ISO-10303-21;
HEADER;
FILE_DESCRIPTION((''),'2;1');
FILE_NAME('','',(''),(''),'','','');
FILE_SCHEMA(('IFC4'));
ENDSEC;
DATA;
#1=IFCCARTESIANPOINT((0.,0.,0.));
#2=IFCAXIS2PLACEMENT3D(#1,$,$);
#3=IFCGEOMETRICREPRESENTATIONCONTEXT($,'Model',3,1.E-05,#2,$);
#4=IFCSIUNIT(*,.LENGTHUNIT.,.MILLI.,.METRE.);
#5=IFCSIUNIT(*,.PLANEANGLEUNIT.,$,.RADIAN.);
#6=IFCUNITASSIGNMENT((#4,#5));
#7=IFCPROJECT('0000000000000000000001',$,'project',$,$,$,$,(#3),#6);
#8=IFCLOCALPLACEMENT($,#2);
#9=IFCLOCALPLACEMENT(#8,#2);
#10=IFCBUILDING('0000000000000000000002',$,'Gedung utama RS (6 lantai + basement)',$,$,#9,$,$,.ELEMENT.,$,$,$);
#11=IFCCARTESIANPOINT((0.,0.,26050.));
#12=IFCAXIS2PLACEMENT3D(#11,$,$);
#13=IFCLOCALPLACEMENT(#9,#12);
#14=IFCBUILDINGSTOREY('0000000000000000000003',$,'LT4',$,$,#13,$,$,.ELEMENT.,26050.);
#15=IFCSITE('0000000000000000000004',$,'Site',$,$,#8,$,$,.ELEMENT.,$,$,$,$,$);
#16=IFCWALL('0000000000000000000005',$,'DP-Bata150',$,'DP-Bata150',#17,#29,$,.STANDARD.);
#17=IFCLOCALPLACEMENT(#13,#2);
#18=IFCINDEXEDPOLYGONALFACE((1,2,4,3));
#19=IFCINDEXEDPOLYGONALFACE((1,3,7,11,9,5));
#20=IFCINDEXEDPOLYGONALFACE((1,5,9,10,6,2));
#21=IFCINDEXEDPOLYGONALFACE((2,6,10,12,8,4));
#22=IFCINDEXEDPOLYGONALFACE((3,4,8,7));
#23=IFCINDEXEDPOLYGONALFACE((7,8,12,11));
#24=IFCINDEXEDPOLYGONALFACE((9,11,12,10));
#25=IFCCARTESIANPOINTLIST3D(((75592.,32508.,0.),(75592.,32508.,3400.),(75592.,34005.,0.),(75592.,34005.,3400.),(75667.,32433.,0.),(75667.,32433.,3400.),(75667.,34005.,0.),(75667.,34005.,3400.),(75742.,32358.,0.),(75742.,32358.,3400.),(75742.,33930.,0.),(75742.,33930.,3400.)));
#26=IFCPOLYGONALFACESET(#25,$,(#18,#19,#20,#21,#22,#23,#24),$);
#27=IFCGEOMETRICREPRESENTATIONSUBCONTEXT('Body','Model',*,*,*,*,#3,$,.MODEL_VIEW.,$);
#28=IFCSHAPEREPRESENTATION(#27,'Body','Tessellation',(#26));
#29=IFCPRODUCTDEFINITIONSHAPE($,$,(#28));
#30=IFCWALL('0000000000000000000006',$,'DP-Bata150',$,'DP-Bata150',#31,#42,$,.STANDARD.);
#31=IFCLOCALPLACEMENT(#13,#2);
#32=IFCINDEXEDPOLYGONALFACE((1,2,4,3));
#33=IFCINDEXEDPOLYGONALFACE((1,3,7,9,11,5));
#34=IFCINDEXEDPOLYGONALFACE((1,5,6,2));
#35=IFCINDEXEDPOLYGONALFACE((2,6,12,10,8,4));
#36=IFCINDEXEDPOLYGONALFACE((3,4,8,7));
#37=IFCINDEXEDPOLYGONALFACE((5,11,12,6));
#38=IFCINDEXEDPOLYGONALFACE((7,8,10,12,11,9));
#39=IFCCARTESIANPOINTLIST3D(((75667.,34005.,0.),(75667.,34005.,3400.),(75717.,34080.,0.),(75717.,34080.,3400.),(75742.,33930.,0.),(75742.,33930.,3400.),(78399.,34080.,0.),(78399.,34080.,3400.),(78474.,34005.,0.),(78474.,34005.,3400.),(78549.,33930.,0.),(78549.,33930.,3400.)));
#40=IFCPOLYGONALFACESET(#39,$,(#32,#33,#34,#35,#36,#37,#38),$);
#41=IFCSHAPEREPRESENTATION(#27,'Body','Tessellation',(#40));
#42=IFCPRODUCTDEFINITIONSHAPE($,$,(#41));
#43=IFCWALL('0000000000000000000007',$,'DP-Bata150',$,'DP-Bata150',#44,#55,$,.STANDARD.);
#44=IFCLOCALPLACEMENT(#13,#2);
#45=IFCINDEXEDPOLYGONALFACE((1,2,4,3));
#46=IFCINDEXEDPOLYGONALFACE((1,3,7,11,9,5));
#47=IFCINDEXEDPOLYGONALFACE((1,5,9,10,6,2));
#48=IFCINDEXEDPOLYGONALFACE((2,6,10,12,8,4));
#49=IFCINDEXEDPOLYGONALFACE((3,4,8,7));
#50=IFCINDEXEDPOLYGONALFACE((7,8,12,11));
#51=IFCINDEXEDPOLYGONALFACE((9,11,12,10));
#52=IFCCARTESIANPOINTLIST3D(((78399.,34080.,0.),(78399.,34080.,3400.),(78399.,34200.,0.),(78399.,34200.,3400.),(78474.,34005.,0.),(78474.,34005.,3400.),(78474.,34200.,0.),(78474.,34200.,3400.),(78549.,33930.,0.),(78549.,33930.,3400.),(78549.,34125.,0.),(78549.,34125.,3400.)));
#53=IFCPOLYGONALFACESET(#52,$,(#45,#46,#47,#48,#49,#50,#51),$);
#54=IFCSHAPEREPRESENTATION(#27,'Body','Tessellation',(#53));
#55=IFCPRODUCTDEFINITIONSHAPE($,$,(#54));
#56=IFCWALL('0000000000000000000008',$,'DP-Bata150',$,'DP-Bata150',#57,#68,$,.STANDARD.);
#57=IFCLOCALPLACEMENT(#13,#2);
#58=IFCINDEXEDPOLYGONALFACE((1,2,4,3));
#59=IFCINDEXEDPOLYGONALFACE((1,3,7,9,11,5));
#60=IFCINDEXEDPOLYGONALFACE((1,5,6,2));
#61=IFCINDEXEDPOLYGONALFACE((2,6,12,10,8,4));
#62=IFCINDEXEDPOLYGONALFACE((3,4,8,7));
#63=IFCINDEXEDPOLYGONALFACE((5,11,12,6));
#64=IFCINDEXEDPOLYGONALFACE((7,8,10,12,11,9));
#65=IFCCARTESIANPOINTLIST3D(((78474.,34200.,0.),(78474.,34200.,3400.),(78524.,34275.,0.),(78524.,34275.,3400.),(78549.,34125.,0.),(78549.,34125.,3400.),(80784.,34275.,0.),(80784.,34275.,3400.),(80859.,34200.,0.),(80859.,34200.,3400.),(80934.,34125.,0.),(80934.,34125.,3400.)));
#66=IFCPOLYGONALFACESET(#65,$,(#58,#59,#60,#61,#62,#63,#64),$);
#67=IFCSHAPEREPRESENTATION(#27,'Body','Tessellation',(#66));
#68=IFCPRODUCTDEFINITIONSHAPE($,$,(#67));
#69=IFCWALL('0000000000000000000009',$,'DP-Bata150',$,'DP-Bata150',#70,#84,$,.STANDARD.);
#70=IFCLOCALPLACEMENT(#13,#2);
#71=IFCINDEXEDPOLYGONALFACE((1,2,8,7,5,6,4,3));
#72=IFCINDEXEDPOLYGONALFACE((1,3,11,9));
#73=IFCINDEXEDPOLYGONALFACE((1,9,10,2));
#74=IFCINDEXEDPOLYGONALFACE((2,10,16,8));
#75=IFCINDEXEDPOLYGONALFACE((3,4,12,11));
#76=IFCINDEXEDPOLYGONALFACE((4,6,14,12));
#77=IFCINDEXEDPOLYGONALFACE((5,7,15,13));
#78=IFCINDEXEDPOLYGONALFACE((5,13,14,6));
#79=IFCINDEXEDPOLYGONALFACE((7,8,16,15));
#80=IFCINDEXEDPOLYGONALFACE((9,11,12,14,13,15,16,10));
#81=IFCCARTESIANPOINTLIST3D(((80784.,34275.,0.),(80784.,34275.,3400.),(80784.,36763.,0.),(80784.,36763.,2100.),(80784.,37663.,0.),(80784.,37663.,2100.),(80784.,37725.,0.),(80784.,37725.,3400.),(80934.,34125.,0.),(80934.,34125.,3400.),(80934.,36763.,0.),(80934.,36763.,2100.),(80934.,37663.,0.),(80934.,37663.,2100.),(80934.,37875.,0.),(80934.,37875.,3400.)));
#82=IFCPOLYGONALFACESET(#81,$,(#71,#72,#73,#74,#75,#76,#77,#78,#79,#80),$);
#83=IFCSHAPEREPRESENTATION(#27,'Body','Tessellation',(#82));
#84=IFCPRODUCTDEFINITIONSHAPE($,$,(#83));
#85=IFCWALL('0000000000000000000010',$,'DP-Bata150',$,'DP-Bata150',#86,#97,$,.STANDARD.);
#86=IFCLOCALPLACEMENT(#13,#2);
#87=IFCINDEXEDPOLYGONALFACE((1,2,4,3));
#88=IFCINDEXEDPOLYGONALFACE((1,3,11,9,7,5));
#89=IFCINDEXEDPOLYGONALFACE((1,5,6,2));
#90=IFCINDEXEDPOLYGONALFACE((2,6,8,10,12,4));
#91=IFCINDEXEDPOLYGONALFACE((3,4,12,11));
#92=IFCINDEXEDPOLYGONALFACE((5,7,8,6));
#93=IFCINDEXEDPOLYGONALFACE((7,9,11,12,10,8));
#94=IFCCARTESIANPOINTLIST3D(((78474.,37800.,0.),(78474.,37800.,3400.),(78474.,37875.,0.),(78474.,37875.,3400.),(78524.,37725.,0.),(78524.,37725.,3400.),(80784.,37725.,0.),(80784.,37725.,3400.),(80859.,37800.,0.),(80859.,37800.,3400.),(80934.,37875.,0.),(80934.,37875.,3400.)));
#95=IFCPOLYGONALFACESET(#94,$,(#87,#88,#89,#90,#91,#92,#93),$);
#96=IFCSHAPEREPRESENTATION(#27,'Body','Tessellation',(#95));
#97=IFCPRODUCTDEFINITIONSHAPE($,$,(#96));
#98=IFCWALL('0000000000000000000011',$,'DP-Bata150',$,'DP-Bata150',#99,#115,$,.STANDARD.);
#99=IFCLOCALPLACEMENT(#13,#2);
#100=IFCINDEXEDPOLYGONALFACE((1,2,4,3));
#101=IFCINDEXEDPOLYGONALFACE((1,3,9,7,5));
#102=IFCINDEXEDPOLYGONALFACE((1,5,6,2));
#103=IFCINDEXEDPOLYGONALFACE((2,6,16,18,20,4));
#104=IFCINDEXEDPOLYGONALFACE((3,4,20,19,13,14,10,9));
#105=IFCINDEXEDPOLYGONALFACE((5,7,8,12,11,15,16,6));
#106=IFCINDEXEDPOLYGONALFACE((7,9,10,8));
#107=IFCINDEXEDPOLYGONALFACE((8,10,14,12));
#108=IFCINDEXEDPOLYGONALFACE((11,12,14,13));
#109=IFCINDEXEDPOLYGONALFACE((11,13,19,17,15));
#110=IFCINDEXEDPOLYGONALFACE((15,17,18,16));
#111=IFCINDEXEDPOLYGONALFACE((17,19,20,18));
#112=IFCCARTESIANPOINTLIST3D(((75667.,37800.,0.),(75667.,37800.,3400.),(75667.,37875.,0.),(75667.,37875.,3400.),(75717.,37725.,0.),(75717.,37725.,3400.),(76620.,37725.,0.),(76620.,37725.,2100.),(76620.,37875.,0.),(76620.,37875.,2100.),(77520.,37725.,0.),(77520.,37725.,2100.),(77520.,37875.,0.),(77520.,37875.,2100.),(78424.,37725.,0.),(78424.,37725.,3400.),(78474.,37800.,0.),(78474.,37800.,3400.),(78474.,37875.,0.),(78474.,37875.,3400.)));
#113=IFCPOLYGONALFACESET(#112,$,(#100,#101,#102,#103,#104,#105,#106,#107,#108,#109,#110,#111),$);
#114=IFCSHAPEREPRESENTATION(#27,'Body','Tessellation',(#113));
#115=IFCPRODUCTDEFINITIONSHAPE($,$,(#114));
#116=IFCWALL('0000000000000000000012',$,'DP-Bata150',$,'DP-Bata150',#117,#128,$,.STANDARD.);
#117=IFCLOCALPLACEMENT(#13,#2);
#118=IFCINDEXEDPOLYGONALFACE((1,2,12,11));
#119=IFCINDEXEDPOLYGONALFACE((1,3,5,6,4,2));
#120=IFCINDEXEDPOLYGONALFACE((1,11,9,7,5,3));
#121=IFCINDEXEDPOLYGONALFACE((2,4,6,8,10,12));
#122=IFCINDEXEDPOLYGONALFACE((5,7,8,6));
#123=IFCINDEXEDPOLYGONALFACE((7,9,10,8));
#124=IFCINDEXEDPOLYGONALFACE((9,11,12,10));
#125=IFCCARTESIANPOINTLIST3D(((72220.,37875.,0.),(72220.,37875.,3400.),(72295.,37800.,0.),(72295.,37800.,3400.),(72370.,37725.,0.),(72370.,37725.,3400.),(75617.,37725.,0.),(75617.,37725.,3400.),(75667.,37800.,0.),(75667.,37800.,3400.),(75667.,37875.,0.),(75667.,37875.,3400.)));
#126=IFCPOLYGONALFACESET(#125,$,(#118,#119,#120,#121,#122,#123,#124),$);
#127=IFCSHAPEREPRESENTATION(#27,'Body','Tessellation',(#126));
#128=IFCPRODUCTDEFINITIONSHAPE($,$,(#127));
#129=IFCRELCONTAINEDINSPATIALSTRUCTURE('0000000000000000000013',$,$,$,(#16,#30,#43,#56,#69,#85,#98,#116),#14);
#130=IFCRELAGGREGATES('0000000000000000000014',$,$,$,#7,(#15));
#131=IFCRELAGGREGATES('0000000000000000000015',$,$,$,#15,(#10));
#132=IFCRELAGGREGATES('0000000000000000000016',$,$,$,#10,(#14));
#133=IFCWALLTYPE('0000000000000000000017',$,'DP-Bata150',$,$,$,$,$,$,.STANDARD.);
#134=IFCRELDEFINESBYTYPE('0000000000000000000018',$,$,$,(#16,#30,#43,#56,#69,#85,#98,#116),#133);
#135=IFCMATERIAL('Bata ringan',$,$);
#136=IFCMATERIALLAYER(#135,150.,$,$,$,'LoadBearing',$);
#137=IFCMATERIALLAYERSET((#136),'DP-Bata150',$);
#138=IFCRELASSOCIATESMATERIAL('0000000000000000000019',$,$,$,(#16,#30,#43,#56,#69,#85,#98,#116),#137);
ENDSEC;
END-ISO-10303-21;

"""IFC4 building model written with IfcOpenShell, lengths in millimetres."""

from ifc_helpers import new_model, si_unit, frame, frame_2d, origin, place, context, subcontext, project, spatial, polyline, rectangle, outline, extrude, material, layer, layer_set, layer_usage, type_object, element, save


model = new_model("IFC4")

# Units and contexts
model_context = context("Model", 3, precision=1e-05, world=origin())
body_context = subcontext(model_context, "Body", "Model", "MODEL_VIEW")
ifc_project = project(units=[si_unit("LENGTHUNIT", "METRE", prefix="MILLI"), si_unit("PLANEANGLEUNIT", "RADIAN")], contexts=[model_context])

# Site, building, storey
site_placement = place(None, origin())
site = spatial("IfcSite", under=ifc_project, at=site_placement, Name="Site", CompositionType="ELEMENT")
building_placement = place(site_placement, origin())
building = spatial("IfcBuilding", under=site, at=building_placement, Name="Gedung utama RS (6 lantai + basement)", CompositionType="ELEMENT")
storey_placement = place(building_placement, frame((0.0, 0.0, 26050.0)))
storey = spatial("IfcBuildingStorey", under=building, at=storey_placement, Name="LT4", CompositionType="ELEMENT", Elevation=26050.0)

# Shared definitions
ifc_material = material(Name="Bata ringan")
ifc_layer_1 = layer(ifc_material, 150.0, Category="LoadBearing")
ifc_layer_set_1 = layer_set([ifc_layer_1], Name="DP-Bata150")
ifc_layer_usage_1 = layer_usage(ifc_layer_set_1, "AXIS2", "NEGATIVE", 75.0)
wall_type_1 = type_object("IfcWallType", Name="DP-Bata150", PredefinedType="STANDARD")

# Walls
wall_1_placement = place(storey_placement, frame((75667.0, 32433.0, 0.0), z_axis=(0.0, 0.0, 1.0), x_axis=(0.0, 1.0, 0.0)))
element("IfcWall", 1, at=wall_1_placement, inside=storey, type_object=wall_type_1, material=ifc_layer_usage_1, Name="DP-Bata150", ObjectType="DP-Bata150", PredefinedType="STANDARD", context=body_context, shape_type="SweptSolid", body=[
    extrude(outline(polyline([(-75.0, -75.0), (0.0, 0.0), (75.0, 75.0), (1572.0, 75.0), (1572.0, 0.0), (1497.0, -75.0), (-75.0, -75.0)])), origin(), (0.0, 0.0, 1.0), 3400.0),
])
wall_2_placement = place(storey_placement, frame((75667.0, 34005.0, 0.0), z_axis=(0.0, 0.0, 1.0), x_axis=(1.0, 0.0, 0.0)))
element("IfcWall", 2, at=wall_2_placement, inside=storey, type_object=wall_type_1, material=ifc_layer_usage_1, Name="DP-Bata150", ObjectType="DP-Bata150", PredefinedType="STANDARD", context=body_context, shape_type="SweptSolid", body=[
    extrude(outline(polyline([(75.0, -75.0), (0.0, 0.0), (50.0, 75.0), (2732.0, 75.0), (2807.0, 0.0), (2882.0, -75.0), (75.0, -75.0)])), origin(), (0.0, 0.0, 1.0), 3400.0),
])
wall_3_placement = place(storey_placement, frame((78474.0, 34005.0, 0.0), z_axis=(0.0, 0.0, 1.0), x_axis=(0.0, 1.0, 0.0)))
element("IfcWall", 3, at=wall_3_placement, inside=storey, type_object=wall_type_1, material=ifc_layer_usage_1, Name="DP-Bata150", ObjectType="DP-Bata150", PredefinedType="STANDARD", context=body_context, shape_type="SweptSolid", body=[
    extrude(outline(polyline([(-75.0, -75.0), (0.0, 0.0), (75.0, 75.0), (195.0, 75.0), (195.0, 0.0), (120.0, -75.0), (-75.0, -75.0)])), origin(), (0.0, 0.0, 1.0), 3400.0),
])
wall_4_placement = place(storey_placement, frame((78474.0, 34200.0, 0.0), z_axis=(0.0, 0.0, 1.0), x_axis=(1.0, 0.0, 0.0)))
element("IfcWall", 4, at=wall_4_placement, inside=storey, type_object=wall_type_1, material=ifc_layer_usage_1, Name="DP-Bata150", ObjectType="DP-Bata150", PredefinedType="STANDARD", context=body_context, shape_type="SweptSolid", body=[
    extrude(outline(polyline([(75.0, -75.0), (0.0, 0.0), (50.0, 75.0), (2310.0, 75.0), (2385.0, 0.0), (2460.0, -75.0), (75.0, -75.0)])), origin(), (0.0, 0.0, 1.0), 3400.0),
])

# Wall, opening
wall_5_placement = place(storey_placement, frame((80859.0, 34200.0, 0.0), z_axis=(0.0, 0.0, 1.0), x_axis=(0.0, 1.0, 0.0)))
wall_5 = element("IfcWall", 5, at=wall_5_placement, inside=storey, type_object=wall_type_1, material=ifc_layer_usage_1, Name="DP-Bata150", ObjectType="DP-Bata150", PredefinedType="STANDARD", context=body_context, shape_type="SweptSolid", body=[
    extrude(outline(polyline([(-75.0, -75.0), (0.0, 0.0), (75.0, 75.0), (3525.0, 75.0), (3600.0, 0.0), (3675.0, -75.0), (-75.0, -75.0)])), origin(), (0.0, 0.0, 1.0), 3400.0),
])
opening_1_placement = place(wall_5_placement, frame((2563.0, 0.0, 0.0), z_axis=(0.0, 0.0, 1.0), x_axis=(1.0, 0.0, 0.0)))
element("IfcOpeningElement", 6, at=opening_1_placement, cuts=wall_5, PredefinedType="OPENING", context=body_context, shape_type="SweptSolid", body=[
    extrude(rectangle(XDim=900.0, YDim=170.0, at=frame_2d((450.0, 0.0))), origin(), (0.0, 0.0, 1.0), 2100.0),
])

# Wall
wall_6_placement = place(storey_placement, frame((80859.0, 37800.0, 0.0), z_axis=(0.0, 0.0, 1.0), x_axis=(-1.0, 0.0, 0.0)))
element("IfcWall", 7, at=wall_6_placement, inside=storey, type_object=wall_type_1, material=ifc_layer_usage_1, Name="DP-Bata150", ObjectType="DP-Bata150", PredefinedType="STANDARD", context=body_context, shape_type="SweptSolid", body=[
    extrude(outline(polyline([(-75.0, -75.0), (0.0, 0.0), (75.0, 75.0), (2335.0, 75.0), (2385.0, 0.0), (2385.0, -75.0), (-75.0, -75.0)])), origin(), (0.0, 0.0, 1.0), 3400.0),
])

# Wall, opening
wall_7_placement = place(storey_placement, frame((78474.0, 37800.0, 0.0), z_axis=(0.0, 0.0, 1.0), x_axis=(-1.0, 0.0, 0.0)))
wall_7 = element("IfcWall", 8, at=wall_7_placement, inside=storey, type_object=wall_type_1, material=ifc_layer_usage_1, Name="DP-Bata150", ObjectType="DP-Bata150", PredefinedType="STANDARD", context=body_context, shape_type="SweptSolid", body=[
    extrude(outline(polyline([(0.0, -75.0), (0.0, 0.0), (50.0, 75.0), (2757.0, 75.0), (2807.0, 0.0), (2807.0, -75.0), (0.0, -75.0)])), origin(), (0.0, 0.0, 1.0), 3400.0),
])
opening_2_placement = place(wall_7_placement, frame((954.0, 0.0, 0.0), z_axis=(0.0, 0.0, 1.0), x_axis=(1.0, 0.0, 0.0)))
element("IfcOpeningElement", 9, at=opening_2_placement, cuts=wall_7, PredefinedType="OPENING", context=body_context, shape_type="SweptSolid", body=[
    extrude(rectangle(XDim=900.0, YDim=170.0, at=frame_2d((450.0, 0.0))), origin(), (0.0, 0.0, 1.0), 2100.0),
])

# Wall
wall_8_placement = place(storey_placement, frame((75667.0, 37800.0, 0.0), z_axis=(0.0, 0.0, 1.0), x_axis=(-1.0, 0.0, 0.0)))
element("IfcWall", 10, at=wall_8_placement, inside=storey, type_object=wall_type_1, material=ifc_layer_usage_1, Name="DP-Bata150", ObjectType="DP-Bata150", PredefinedType="STANDARD", context=body_context, shape_type="SweptSolid", body=[
    extrude(outline(polyline([(0.0, -75.0), (0.0, 0.0), (50.0, 75.0), (3297.0, 75.0), (3372.0, 0.0), (3447.0, -75.0), (0.0, -75.0)])), origin(), (0.0, 0.0, 1.0), 3400.0),
])

save(model, "model.ifc")
